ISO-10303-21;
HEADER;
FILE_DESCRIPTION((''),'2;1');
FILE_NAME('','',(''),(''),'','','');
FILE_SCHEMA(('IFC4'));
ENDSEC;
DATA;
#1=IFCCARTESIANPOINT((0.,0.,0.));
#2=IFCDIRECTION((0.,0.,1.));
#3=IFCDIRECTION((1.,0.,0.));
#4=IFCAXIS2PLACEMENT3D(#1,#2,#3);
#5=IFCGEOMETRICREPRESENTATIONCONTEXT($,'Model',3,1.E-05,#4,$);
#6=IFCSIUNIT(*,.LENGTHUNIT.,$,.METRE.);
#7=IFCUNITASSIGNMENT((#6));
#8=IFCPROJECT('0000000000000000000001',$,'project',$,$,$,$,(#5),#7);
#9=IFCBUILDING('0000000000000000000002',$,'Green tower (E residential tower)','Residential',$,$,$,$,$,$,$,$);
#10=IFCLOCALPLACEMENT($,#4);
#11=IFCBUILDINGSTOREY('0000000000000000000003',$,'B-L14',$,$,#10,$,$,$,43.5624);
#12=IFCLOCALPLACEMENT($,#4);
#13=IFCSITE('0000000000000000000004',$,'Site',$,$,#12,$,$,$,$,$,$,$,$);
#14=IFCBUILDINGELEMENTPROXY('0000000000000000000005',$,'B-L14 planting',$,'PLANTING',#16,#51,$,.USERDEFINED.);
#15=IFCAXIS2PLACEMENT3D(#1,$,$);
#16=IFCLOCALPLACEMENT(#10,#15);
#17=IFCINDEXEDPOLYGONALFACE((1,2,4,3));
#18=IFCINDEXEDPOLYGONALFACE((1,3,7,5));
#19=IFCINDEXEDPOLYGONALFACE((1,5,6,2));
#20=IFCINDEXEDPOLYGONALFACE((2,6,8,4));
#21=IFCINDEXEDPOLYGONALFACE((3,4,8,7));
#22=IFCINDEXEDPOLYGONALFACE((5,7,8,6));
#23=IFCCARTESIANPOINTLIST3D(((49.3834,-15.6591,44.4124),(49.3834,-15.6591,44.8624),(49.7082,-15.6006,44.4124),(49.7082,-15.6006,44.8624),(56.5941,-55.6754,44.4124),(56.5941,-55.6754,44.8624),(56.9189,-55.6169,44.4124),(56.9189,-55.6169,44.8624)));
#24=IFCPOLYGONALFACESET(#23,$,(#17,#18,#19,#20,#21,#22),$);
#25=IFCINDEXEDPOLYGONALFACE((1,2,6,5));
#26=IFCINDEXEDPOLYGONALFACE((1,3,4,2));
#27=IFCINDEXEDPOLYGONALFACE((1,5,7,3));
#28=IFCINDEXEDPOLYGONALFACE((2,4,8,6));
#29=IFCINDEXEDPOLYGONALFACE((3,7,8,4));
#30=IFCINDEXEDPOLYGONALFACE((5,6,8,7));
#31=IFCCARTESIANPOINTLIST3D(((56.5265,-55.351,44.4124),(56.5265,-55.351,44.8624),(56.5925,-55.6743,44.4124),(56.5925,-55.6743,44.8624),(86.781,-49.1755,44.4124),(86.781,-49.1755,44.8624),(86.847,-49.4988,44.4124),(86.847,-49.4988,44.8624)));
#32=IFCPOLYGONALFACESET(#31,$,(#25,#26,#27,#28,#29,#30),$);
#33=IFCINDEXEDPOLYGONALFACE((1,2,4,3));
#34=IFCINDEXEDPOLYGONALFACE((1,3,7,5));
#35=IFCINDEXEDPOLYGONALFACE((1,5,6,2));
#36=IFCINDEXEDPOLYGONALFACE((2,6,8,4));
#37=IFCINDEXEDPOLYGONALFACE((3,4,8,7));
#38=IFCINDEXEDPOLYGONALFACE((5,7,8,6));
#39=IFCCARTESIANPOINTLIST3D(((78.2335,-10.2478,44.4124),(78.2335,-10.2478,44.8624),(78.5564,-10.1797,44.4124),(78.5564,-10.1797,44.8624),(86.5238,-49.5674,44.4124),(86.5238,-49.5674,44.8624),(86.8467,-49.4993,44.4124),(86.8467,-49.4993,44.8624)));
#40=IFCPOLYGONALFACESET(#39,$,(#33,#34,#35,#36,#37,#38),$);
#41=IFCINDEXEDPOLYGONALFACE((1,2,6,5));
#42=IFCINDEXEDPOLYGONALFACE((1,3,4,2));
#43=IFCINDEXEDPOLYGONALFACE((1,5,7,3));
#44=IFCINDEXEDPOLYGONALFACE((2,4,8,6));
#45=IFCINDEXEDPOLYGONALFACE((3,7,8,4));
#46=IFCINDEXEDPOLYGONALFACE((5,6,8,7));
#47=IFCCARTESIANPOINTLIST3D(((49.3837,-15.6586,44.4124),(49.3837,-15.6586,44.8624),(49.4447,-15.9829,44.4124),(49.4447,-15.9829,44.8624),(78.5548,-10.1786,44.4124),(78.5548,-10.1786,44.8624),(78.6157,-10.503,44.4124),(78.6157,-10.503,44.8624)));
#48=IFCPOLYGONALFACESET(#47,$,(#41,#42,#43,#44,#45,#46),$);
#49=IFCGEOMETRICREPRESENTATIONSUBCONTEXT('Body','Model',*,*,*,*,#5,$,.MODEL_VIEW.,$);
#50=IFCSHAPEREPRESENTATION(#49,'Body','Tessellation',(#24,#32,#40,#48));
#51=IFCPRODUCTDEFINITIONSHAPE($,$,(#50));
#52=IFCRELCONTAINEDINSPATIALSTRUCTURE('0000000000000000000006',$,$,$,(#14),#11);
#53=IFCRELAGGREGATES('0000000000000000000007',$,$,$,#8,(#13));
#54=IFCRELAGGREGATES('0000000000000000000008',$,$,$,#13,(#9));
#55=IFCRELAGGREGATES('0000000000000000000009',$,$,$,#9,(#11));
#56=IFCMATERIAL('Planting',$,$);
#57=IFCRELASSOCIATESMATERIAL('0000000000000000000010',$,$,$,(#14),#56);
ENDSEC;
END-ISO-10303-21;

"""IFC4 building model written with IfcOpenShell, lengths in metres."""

from ifc_helpers import new_model, si_unit, frame, origin_with_axes, place, context, subcontext, project, spatial, polyline, outline, extrude, material, element, save


model = new_model("IFC4")

# Units and contexts
model_context = context("Model", 3, precision=1e-05, world=origin_with_axes())
body_context = subcontext(model_context, "Body", "Model", "MODEL_VIEW")
ifc_project = project(units=[si_unit("LENGTHUNIT", "METRE")], contexts=[model_context])

# Site, building, storey
site_placement = place(None, origin_with_axes())
site = spatial("IfcSite", under=ifc_project, at=site_placement, Name="Site")
building = spatial("IfcBuilding", under=site, Name="Green tower (E residential tower)", Description="Residential")
storey_placement = place(None, origin_with_axes())
storey = spatial("IfcBuildingStorey", under=building, at=storey_placement, Name="B-L14", Elevation=43.5624)

# Building element proxy
ifc_material_1 = material(Name="Planting")
proxy_1_placement = place(storey_placement, origin_with_axes())
element("IfcBuildingElementProxy", 1, at=proxy_1_placement, inside=storey, material=ifc_material_1, Name="B-L14 planting", ObjectType="PLANTING", PredefinedType="USERDEFINED", context=body_context, shape_type="SweptSolid", body=[
    extrude(outline(polyline([(49.3834, -15.6591), (56.5941, -55.6754), (56.9189, -55.6169), (49.7082, -15.6006), (49.3834, -15.6591)])), frame((0.0, 0.0, 44.4124), z_axis=(0.0, 0.0, 1.0), x_axis=(1.0, 0.0, 0.0)), (0.0, 0.0, 1.0), 0.45),
    extrude(outline(polyline([(56.5925, -55.6743), (86.847, -49.4988), (86.781, -49.1755), (56.5265, -55.351), (56.5925, -55.6743)])), frame((0.0, 0.0, 44.4124), z_axis=(0.0, 0.0, 1.0), x_axis=(1.0, 0.0, 0.0)), (0.0, 0.0, 1.0), 0.45),
    extrude(outline(polyline([(86.8467, -49.4993), (78.5564, -10.1797), (78.2335, -10.2478), (86.5238, -49.5674), (86.8467, -49.4993)])), frame((0.0, 0.0, 44.4124), z_axis=(0.0, 0.0, 1.0), x_axis=(1.0, 0.0, 0.0)), (0.0, 0.0, 1.0), 0.45),
    extrude(outline(polyline([(78.5548, -10.1786), (49.3837, -15.6586), (49.4447, -15.9829), (78.6157, -10.503), (78.5548, -10.1786)])), frame((0.0, 0.0, 44.4124), z_axis=(0.0, 0.0, 1.0), x_axis=(1.0, 0.0, 0.0)), (0.0, 0.0, 1.0), 0.45),
])

save(model, "model.ifc")
